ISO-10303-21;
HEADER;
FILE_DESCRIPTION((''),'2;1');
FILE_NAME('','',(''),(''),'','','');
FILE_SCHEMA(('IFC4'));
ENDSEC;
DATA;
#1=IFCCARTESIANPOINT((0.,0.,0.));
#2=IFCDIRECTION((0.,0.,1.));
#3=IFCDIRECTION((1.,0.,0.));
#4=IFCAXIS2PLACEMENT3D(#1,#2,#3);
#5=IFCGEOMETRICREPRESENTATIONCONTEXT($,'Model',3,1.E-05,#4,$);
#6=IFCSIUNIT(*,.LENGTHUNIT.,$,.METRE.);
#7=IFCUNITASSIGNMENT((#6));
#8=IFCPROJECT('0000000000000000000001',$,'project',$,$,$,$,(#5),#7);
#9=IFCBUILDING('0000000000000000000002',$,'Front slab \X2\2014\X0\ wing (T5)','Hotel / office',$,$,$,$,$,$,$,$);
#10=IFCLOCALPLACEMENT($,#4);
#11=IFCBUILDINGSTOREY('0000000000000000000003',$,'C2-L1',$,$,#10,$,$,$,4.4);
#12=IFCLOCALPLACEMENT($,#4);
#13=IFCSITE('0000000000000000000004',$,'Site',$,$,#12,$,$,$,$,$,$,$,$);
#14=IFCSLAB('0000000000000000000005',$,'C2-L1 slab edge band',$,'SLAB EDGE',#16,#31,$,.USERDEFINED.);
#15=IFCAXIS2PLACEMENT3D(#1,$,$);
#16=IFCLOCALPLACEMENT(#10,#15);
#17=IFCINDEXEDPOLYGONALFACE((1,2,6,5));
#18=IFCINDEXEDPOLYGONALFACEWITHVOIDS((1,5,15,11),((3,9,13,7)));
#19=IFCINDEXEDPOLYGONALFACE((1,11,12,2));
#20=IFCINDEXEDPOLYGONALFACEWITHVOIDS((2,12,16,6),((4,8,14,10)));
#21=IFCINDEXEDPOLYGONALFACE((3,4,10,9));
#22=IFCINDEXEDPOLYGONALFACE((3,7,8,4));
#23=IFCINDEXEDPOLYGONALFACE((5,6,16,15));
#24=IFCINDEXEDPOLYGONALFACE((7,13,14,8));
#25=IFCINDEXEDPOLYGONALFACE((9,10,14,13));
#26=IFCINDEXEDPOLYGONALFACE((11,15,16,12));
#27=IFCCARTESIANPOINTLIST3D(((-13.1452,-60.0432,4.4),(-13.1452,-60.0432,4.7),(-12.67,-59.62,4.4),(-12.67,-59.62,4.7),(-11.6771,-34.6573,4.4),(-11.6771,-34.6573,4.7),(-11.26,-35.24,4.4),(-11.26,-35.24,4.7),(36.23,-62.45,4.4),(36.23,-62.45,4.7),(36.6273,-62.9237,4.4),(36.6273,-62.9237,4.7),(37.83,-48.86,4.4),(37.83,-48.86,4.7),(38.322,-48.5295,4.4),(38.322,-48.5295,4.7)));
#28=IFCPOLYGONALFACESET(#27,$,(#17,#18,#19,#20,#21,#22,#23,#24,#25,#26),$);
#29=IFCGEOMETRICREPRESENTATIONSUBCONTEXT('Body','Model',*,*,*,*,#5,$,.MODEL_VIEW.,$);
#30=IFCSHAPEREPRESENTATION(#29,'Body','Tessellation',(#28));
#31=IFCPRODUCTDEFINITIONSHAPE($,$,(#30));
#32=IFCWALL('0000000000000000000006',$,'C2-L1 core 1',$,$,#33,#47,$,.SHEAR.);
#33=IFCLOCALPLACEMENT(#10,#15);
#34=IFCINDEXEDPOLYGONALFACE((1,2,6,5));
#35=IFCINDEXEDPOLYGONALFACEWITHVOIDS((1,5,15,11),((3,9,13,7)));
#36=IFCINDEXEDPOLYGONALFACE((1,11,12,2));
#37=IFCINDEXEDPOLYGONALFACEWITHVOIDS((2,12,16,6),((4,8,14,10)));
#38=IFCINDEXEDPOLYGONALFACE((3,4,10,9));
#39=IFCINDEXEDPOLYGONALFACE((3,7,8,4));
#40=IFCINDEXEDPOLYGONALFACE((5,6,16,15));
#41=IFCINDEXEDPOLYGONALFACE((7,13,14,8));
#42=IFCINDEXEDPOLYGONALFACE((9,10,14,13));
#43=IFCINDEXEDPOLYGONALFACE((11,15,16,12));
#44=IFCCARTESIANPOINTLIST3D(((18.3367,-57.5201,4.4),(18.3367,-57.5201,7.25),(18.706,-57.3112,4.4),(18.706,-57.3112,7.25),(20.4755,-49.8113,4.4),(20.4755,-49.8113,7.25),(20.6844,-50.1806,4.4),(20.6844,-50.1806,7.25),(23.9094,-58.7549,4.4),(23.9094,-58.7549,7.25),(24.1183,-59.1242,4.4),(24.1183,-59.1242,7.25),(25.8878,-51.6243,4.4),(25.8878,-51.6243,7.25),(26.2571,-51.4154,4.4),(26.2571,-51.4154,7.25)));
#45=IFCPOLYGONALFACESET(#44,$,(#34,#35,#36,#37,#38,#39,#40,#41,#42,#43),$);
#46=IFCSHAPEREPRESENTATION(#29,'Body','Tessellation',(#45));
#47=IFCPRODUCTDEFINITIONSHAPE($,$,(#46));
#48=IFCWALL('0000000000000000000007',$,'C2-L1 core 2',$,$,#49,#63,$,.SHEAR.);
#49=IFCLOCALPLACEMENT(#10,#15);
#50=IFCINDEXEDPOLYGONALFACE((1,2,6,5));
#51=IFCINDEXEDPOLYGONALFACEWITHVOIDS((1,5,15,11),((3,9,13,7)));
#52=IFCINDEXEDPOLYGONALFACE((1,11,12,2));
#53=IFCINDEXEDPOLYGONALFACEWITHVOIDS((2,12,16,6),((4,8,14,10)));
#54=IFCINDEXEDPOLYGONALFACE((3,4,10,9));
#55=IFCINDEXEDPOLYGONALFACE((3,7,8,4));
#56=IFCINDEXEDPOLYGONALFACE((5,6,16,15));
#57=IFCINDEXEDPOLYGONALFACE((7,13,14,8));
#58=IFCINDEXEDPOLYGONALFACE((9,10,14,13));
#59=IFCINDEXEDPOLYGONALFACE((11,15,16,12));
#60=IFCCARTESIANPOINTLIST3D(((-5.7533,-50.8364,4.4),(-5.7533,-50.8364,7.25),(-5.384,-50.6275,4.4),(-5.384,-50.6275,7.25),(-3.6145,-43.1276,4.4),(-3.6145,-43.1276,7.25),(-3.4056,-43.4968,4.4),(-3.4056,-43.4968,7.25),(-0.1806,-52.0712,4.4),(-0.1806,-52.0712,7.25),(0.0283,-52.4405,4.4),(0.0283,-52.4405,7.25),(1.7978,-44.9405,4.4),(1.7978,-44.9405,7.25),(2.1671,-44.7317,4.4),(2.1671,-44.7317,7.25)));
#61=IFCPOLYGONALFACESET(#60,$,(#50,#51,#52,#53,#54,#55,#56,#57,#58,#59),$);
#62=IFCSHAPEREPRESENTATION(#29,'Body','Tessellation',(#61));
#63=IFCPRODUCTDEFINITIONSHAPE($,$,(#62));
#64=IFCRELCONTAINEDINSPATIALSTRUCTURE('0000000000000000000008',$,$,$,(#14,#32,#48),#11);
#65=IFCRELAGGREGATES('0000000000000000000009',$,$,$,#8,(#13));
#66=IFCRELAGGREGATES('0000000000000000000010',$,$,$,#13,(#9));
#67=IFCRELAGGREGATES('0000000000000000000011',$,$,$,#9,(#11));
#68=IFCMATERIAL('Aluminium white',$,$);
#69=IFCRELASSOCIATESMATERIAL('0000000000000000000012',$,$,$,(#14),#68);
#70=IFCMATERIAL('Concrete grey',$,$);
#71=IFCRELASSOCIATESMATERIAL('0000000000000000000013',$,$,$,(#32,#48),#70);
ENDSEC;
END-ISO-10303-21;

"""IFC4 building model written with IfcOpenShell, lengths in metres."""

from ifc_helpers import new_model, si_unit, frame, origin_with_axes, place, context, subcontext, project, spatial, polyline, outline, extrude, material, element, save


model = new_model("IFC4")

# Units and contexts
model_context = context("Model", 3, precision=1e-05, world=origin_with_axes())
body_context = subcontext(model_context, "Body", "Model", "MODEL_VIEW")
ifc_project = project(units=[si_unit("LENGTHUNIT", "METRE")], contexts=[model_context])

# Site, building, storey
site_placement = place(None, origin_with_axes())
site = spatial("IfcSite", under=ifc_project, at=site_placement, Name="Site")
building = spatial("IfcBuilding", under=site, Name="Front slab — wing (T5)", Description="Hotel / office")
storey_placement = place(None, origin_with_axes())
storey = spatial("IfcBuildingStorey", under=building, at=storey_placement, Name="C2-L1", Elevation=4.4)

# Shared definitions
ifc_material_1 = material(Name="Aluminium white")

# Slab
slab_placement = place(storey_placement, origin_with_axes())
element("IfcSlab", 1, at=slab_placement, inside=storey, material=ifc_material_1, Name="C2-L1 slab edge band", ObjectType="SLAB EDGE", PredefinedType="USERDEFINED", context=body_context, shape_type="SweptSolid", body=[
    extrude(outline(polyline([(-11.6771, -34.6573), (-13.1452, -60.0432), (36.6273, -62.9237), (38.322, -48.5295), (-11.6771, -34.6573)]), holes=[polyline([(-11.26, -35.24), (-12.67, -59.62), (36.23, -62.45), (37.83, -48.86), (-11.26, -35.24)])]), frame((0.0, 0.0, 4.4), z_axis=(0.0, 0.0, 1.0), x_axis=(1.0, 0.0, 0.0)), (0.0, 0.0, 1.0), 0.3),
])

# Walls
ifc_material_2 = material(Name="Concrete grey")
wall_1_placement = place(storey_placement, origin_with_axes())
element("IfcWall", 2, at=wall_1_placement, inside=storey, material=ifc_material_2, Name="C2-L1 core 1", PredefinedType="SHEAR", context=body_context, shape_type="SweptSolid", body=[
    extrude(outline(polyline([(26.2571, -51.4154), (20.4755, -49.8113), (18.3367, -57.5201), (24.1183, -59.1242), (26.2571, -51.4154)]), holes=[polyline([(25.8878, -51.6243), (20.6844, -50.1806), (18.706, -57.3112), (23.9094, -58.7549), (25.8878, -51.6243)])]), frame((0.0, 0.0, 4.4), z_axis=(0.0, 0.0, 1.0), x_axis=(1.0, 0.0, 0.0)), (0.0, 0.0, 1.0), 2.85),
])
wall_2_placement = place(storey_placement, origin_with_axes())
element("IfcWall", 3, at=wall_2_placement, inside=storey, material=ifc_material_2, Name="C2-L1 core 2", PredefinedType="SHEAR", context=body_context, shape_type="SweptSolid", body=[
    extrude(outline(polyline([(2.1671, -44.7317), (-3.6145, -43.1276), (-5.7533, -50.8364), (0.0283, -52.4405), (2.1671, -44.7317)]), holes=[polyline([(1.7978, -44.9405), (-3.4056, -43.4968), (-5.384, -50.6275), (-0.1806, -52.0712), (1.7978, -44.9405)])]), frame((0.0, 0.0, 4.4), z_axis=(0.0, 0.0, 1.0), x_axis=(1.0, 0.0, 0.0)), (0.0, 0.0, 1.0), 2.85),
])

save(model, "model.ifc")
